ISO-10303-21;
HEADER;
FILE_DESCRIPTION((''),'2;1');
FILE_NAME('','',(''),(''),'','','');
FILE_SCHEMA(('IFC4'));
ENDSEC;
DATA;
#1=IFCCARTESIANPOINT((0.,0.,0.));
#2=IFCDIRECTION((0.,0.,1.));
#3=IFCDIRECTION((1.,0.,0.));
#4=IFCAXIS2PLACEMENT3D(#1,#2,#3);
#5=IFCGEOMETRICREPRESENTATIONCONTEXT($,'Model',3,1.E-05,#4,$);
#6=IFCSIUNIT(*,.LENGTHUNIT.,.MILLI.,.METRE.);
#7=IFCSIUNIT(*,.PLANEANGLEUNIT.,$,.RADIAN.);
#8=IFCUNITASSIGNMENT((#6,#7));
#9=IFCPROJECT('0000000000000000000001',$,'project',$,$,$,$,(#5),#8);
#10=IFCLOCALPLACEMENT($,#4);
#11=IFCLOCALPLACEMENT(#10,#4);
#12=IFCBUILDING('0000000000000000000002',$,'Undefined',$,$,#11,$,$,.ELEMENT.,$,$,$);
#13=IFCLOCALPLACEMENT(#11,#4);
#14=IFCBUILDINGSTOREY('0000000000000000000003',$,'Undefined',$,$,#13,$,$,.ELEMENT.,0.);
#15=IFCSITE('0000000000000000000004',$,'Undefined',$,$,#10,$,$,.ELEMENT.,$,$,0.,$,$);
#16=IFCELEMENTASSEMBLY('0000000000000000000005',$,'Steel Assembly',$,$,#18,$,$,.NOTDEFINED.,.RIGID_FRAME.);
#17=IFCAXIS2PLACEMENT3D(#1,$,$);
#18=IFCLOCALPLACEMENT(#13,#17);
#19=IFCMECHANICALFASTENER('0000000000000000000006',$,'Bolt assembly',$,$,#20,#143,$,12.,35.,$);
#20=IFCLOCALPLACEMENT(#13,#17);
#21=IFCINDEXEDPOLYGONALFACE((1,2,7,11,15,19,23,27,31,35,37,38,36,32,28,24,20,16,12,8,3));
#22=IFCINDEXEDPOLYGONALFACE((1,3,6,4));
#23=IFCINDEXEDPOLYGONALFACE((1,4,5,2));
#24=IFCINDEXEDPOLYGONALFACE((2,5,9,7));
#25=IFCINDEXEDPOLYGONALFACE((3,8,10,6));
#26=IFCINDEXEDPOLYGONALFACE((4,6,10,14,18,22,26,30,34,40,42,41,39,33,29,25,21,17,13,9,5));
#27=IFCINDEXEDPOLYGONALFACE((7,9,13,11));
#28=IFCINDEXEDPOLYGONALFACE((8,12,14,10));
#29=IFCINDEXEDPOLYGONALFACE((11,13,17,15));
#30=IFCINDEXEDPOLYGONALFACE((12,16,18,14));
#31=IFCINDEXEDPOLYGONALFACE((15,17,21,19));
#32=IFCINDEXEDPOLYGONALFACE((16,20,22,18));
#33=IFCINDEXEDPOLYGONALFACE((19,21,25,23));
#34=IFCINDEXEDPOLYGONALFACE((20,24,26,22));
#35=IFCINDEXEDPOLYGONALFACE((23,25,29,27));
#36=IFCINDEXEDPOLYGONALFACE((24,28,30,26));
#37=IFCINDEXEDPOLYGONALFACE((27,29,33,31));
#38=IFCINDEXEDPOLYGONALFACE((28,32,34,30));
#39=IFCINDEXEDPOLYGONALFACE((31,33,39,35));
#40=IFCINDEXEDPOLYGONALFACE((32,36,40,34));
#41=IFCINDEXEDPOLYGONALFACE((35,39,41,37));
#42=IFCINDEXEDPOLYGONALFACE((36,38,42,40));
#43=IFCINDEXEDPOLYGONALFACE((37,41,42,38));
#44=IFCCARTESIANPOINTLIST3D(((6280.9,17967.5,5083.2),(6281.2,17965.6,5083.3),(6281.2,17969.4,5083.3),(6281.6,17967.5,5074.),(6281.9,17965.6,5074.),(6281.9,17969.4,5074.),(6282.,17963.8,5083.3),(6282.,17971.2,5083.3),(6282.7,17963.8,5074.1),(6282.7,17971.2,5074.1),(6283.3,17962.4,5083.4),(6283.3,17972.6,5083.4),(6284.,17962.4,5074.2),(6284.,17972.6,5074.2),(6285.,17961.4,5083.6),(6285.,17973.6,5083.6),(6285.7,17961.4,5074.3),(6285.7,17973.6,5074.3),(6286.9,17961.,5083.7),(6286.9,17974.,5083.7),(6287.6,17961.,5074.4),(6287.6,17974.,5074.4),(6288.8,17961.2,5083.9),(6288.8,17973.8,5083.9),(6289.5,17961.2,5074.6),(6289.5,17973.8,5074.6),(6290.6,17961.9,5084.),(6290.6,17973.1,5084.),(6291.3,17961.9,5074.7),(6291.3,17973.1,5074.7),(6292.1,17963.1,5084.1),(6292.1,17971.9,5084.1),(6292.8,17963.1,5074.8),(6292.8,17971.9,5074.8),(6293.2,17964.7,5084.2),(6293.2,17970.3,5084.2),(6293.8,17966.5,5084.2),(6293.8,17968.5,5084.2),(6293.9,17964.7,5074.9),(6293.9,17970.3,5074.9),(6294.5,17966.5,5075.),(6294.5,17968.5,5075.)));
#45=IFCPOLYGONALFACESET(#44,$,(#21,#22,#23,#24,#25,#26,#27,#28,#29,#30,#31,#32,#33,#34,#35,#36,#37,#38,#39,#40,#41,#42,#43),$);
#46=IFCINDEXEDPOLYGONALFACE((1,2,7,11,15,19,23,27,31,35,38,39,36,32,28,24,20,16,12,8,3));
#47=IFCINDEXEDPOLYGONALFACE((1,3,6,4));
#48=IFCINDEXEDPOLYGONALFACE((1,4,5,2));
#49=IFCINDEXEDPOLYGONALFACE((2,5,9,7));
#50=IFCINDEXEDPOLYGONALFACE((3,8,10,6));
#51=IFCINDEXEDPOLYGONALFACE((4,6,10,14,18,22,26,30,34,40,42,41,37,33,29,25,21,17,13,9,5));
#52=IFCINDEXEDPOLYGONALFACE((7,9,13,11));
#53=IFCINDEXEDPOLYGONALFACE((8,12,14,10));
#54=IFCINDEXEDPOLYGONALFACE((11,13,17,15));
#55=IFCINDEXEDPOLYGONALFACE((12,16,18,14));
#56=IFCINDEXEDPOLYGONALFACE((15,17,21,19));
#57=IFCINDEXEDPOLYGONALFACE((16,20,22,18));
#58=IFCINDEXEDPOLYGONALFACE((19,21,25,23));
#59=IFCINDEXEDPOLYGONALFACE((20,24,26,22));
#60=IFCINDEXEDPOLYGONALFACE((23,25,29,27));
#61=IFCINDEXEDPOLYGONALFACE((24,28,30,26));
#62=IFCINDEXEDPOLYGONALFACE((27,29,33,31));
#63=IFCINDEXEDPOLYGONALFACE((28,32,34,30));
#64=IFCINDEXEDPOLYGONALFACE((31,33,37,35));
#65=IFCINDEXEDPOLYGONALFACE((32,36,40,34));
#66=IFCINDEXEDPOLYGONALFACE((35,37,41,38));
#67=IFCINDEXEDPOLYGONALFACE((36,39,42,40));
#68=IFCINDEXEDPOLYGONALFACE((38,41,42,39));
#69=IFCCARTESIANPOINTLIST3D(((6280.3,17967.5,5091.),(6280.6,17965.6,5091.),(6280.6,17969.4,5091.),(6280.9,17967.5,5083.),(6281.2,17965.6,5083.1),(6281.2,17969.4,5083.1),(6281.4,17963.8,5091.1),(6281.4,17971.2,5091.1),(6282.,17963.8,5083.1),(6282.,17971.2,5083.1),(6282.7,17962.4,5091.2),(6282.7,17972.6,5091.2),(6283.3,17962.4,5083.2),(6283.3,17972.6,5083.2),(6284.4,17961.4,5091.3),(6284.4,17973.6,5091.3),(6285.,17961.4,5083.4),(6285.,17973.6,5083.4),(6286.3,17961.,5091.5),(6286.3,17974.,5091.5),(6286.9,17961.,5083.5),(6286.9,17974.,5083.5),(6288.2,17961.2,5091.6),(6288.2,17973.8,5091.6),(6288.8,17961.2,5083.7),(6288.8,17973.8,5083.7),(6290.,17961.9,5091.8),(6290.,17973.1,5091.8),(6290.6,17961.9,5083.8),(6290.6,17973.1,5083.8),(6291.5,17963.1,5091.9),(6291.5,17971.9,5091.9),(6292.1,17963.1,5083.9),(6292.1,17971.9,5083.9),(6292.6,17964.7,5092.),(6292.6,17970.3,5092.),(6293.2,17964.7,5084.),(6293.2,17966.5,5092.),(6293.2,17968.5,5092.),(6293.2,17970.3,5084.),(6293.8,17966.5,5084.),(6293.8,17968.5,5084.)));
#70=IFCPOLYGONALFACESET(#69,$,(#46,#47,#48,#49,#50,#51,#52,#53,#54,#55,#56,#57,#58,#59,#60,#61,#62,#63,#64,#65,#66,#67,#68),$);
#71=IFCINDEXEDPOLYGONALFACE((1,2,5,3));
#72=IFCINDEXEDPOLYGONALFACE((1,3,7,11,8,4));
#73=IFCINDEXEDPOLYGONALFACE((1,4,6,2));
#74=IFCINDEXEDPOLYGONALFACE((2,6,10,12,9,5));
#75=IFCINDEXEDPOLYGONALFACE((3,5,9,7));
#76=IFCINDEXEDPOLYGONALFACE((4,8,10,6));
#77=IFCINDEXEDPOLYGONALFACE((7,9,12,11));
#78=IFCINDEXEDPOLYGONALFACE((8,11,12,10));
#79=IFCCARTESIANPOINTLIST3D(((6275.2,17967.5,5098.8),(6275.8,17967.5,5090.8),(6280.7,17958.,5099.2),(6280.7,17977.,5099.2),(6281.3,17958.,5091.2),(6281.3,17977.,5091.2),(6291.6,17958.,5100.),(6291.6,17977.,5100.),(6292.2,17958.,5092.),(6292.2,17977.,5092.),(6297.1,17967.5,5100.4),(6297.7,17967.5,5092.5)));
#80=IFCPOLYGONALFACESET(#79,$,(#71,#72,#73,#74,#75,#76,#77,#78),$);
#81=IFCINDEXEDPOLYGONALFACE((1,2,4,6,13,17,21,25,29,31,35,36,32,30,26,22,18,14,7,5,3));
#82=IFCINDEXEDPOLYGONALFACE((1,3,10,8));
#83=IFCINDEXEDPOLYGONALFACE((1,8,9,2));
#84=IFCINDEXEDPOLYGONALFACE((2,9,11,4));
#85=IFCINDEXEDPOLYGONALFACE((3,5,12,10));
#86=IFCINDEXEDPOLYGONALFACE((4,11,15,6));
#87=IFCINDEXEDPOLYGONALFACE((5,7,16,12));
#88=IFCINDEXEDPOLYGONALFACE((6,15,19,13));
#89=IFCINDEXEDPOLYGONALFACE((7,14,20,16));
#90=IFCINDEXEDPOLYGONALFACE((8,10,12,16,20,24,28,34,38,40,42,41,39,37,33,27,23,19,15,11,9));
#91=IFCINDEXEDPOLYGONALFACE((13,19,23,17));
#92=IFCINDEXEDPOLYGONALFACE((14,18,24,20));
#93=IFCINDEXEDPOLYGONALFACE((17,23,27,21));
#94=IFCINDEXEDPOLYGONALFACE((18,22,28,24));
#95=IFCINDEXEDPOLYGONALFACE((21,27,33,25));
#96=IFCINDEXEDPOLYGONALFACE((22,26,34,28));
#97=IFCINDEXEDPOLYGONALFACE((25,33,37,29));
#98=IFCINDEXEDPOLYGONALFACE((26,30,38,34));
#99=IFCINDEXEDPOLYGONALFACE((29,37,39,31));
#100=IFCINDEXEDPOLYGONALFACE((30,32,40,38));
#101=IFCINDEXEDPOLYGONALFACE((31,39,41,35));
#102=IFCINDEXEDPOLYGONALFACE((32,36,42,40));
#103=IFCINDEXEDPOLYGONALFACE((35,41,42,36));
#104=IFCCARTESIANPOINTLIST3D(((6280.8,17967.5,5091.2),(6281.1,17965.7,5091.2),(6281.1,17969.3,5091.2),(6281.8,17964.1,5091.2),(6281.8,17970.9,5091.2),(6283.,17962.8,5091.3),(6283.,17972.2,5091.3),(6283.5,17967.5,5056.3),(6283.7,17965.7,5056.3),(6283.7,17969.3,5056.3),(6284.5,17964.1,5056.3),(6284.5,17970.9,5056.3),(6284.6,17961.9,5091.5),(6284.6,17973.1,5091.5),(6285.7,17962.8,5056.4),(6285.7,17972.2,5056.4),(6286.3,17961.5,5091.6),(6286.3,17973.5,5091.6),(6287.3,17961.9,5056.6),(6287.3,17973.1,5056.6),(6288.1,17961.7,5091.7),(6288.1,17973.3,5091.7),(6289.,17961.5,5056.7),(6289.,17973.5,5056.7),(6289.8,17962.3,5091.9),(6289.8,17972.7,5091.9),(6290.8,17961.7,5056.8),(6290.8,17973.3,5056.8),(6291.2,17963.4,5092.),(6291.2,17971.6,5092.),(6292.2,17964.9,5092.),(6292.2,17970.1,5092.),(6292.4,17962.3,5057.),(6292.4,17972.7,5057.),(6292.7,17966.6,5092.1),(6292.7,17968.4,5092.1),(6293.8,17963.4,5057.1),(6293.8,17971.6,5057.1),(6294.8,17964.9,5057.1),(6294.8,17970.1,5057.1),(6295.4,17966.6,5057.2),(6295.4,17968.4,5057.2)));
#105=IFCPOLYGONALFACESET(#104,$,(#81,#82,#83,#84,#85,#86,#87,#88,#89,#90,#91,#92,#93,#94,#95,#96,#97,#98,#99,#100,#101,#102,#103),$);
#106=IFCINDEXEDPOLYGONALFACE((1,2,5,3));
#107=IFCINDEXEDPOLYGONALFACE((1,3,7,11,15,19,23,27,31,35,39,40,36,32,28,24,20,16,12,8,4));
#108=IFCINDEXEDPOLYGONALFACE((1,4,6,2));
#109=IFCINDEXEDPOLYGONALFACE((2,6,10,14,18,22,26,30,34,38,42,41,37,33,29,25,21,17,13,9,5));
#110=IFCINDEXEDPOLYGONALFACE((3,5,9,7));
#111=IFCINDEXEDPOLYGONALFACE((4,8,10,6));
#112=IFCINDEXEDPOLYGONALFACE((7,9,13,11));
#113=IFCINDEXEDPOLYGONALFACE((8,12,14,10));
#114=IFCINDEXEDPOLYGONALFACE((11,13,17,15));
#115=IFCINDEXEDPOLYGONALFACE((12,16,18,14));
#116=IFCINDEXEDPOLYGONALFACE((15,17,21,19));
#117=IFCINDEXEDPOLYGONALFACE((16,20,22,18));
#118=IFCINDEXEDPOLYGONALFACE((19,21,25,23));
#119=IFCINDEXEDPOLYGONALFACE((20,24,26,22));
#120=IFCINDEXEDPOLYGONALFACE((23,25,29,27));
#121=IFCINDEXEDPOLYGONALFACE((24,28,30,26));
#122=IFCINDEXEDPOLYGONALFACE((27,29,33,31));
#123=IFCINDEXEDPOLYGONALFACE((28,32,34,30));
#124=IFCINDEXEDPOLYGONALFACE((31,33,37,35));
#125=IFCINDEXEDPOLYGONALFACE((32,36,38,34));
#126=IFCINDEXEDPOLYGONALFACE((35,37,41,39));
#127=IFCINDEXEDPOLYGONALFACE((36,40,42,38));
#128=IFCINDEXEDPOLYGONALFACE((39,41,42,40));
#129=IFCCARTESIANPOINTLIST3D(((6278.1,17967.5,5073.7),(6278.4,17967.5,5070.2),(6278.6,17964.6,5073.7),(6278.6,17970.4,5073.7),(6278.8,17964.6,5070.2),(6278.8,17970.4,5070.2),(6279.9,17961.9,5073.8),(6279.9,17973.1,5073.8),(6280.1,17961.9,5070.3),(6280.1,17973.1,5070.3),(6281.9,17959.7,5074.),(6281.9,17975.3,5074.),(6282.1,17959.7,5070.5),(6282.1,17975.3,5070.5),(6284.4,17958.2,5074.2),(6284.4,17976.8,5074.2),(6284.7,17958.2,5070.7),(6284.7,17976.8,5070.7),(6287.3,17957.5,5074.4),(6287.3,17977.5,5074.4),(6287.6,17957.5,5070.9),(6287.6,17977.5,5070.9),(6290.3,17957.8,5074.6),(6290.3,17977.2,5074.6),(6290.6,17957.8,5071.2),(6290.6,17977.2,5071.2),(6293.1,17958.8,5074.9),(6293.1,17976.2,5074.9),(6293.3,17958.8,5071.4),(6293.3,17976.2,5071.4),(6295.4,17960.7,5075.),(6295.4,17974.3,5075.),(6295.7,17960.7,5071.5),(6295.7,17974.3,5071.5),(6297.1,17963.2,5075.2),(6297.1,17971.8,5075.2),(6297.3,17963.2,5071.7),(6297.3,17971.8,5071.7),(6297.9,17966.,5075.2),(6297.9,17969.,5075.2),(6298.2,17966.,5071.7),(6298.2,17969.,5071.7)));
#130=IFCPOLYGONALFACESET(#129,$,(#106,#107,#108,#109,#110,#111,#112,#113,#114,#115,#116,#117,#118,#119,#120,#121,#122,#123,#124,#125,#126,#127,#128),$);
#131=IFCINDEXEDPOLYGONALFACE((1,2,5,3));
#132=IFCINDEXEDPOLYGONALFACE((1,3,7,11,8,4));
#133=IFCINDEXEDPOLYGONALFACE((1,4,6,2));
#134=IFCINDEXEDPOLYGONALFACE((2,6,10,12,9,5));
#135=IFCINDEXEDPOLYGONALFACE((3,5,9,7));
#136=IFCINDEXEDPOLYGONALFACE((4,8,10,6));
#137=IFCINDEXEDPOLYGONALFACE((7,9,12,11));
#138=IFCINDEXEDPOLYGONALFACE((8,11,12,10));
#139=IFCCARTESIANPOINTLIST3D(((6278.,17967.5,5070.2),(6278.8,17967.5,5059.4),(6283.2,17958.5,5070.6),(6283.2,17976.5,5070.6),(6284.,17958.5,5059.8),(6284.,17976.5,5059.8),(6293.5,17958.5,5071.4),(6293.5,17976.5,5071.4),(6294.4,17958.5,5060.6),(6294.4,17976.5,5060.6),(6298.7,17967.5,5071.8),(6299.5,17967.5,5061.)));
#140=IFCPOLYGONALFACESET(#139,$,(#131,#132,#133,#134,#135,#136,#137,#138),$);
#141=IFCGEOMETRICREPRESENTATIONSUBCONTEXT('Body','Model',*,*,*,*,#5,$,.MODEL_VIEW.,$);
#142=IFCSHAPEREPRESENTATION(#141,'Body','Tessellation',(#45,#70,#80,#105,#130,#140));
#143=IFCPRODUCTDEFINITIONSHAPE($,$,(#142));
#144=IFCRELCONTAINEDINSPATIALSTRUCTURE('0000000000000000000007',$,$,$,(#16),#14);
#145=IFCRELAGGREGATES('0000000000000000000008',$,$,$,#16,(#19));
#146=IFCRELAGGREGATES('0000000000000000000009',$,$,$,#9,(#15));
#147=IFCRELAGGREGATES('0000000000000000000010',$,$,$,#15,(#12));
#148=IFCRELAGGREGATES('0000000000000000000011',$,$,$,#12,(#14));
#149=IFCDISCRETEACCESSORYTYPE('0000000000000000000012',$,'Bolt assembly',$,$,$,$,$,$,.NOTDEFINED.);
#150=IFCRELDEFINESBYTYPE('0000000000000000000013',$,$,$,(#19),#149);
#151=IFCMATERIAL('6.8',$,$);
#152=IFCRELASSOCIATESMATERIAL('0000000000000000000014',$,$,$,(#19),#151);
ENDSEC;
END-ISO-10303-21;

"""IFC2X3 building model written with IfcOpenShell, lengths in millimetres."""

from ifc_helpers import new_model, si_unit, frame, origin_with_axes, origin_2d_with_axis, place, context, subcontext, project, spatial, polyline, circle, outline, extrude, source, transform, mapped, material, type_object, element, aggregate, save


model = new_model("IFC2X3")

# Units and contexts
model_context = context("Model", 3, precision=1e-05, world=origin_with_axes())
body_context = subcontext(model_context, "Body", "Model", "MODEL_VIEW")
ifc_project = project(units=[si_unit("LENGTHUNIT", "METRE", prefix="MILLI"), si_unit("PLANEANGLEUNIT", "RADIAN")], contexts=[model_context])

# Site, building, storey
site_placement = place(None, origin_with_axes())
site = spatial("IfcSite", under=ifc_project, at=site_placement, Name="Undefined", CompositionType="ELEMENT", RefElevation=0.0)
building_placement = place(site_placement, origin_with_axes())
building = spatial("IfcBuilding", under=site, at=building_placement, Name="Undefined", CompositionType="ELEMENT")
storey_placement = place(building_placement, origin_with_axes())
storey = spatial("IfcBuildingStorey", under=building, at=storey_placement, Name="Undefined", CompositionType="ELEMENT", Elevation=0.0)

# Element assembly, mechanical fastener
assembly_1_placement = place(storey_placement, origin_with_axes())
assembly_1 = element("IfcElementAssembly", 1, at=assembly_1_placement, inside=storey, Name="Steel Assembly", AssemblyPlace="NOTDEFINED", PredefinedType="RIGID_FRAME")
ifc_material_1 = material(Name="6.8")
discrete_accessory_type_1 = type_object("IfcDiscreteAccessoryType", Name="Bolt assembly")
shared_shape_1 = source(origin_with_axes(), body_context, "Body", "SweptSolid", [
    extrude(circle(Radius=6.5, at=origin_2d_with_axis()), frame((0.0, -0.1, 0.0), z_axis=(0.0, 1.0, 0.0), x_axis=(1.0, 0.0, 0.0)), (0.0, 0.0, 1.0), 9.3),
    extrude(circle(Radius=6.5, at=origin_2d_with_axis()), frame((0.0, -7.9, 0.0), z_axis=(0.0, 1.0, 0.0), x_axis=(1.0, 0.0, 0.0)), (0.0, 0.0, 1.0), 8.0),
    extrude(outline(polyline([(11.0, 0.0), (5.5, 9.5), (-5.5, 9.5), (-11.0, 0.0), (-5.5, -9.5), (5.5, -9.5), (11.0, 0.0)])), frame((0.0, -16.0, 0.0), z_axis=(0.0, 1.0, 0.0), x_axis=(1.0, 0.0, 0.0)), (0.0, 0.0, 1.0), 8.0),
    extrude(circle(Radius=6.0, at=origin_2d_with_axis()), frame((0.0, -8.0, 0.0), z_axis=(0.0, 1.0, 0.0), x_axis=(1.0, 0.0, 0.0)), (0.0, 0.0, 1.0), 35.0),
    extrude(circle(Radius=10.0, at=origin_2d_with_axis()), frame((0.0, 9.2, 0.0), z_axis=(0.0, 1.0, 0.0), x_axis=(1.0, 0.0, 0.0)), (0.0, 0.0, 1.0), 3.5),
    extrude(outline(polyline([(10.4, 0.0), (5.2, 9.0), (-5.2, 9.0), (-10.4, 0.0), (-5.2, -9.0), (5.2, -9.0), (10.4, 0.0)])), frame((0.0, 12.7, 0.0), z_axis=(0.0, 1.0, 0.0), x_axis=(1.0, 0.0, 0.0)), (0.0, 0.0, 1.0), 10.8),
])
mechanical_fastener_1_placement = place(assembly_1_placement, frame((6287.4, 17967.5, 5083.6), z_axis=(0.0, -1.0, 0.0), x_axis=(-0.997054, 0.0, -0.076696)))
mechanical_fastener_1 = element("IfcMechanicalFastener", 2, at=mechanical_fastener_1_placement, type_object=discrete_accessory_type_1, material=ifc_material_1, Name="Bolt assembly", NominalDiameter=12.0, NominalLength=35.0, context=body_context, shape_type="MappedRepresentation", body=[
    mapped(shared_shape_1, transform((0.0, 0.0, 0.0))),
])
aggregate(assembly_1, [mechanical_fastener_1])

save(model, "model.ifc")
